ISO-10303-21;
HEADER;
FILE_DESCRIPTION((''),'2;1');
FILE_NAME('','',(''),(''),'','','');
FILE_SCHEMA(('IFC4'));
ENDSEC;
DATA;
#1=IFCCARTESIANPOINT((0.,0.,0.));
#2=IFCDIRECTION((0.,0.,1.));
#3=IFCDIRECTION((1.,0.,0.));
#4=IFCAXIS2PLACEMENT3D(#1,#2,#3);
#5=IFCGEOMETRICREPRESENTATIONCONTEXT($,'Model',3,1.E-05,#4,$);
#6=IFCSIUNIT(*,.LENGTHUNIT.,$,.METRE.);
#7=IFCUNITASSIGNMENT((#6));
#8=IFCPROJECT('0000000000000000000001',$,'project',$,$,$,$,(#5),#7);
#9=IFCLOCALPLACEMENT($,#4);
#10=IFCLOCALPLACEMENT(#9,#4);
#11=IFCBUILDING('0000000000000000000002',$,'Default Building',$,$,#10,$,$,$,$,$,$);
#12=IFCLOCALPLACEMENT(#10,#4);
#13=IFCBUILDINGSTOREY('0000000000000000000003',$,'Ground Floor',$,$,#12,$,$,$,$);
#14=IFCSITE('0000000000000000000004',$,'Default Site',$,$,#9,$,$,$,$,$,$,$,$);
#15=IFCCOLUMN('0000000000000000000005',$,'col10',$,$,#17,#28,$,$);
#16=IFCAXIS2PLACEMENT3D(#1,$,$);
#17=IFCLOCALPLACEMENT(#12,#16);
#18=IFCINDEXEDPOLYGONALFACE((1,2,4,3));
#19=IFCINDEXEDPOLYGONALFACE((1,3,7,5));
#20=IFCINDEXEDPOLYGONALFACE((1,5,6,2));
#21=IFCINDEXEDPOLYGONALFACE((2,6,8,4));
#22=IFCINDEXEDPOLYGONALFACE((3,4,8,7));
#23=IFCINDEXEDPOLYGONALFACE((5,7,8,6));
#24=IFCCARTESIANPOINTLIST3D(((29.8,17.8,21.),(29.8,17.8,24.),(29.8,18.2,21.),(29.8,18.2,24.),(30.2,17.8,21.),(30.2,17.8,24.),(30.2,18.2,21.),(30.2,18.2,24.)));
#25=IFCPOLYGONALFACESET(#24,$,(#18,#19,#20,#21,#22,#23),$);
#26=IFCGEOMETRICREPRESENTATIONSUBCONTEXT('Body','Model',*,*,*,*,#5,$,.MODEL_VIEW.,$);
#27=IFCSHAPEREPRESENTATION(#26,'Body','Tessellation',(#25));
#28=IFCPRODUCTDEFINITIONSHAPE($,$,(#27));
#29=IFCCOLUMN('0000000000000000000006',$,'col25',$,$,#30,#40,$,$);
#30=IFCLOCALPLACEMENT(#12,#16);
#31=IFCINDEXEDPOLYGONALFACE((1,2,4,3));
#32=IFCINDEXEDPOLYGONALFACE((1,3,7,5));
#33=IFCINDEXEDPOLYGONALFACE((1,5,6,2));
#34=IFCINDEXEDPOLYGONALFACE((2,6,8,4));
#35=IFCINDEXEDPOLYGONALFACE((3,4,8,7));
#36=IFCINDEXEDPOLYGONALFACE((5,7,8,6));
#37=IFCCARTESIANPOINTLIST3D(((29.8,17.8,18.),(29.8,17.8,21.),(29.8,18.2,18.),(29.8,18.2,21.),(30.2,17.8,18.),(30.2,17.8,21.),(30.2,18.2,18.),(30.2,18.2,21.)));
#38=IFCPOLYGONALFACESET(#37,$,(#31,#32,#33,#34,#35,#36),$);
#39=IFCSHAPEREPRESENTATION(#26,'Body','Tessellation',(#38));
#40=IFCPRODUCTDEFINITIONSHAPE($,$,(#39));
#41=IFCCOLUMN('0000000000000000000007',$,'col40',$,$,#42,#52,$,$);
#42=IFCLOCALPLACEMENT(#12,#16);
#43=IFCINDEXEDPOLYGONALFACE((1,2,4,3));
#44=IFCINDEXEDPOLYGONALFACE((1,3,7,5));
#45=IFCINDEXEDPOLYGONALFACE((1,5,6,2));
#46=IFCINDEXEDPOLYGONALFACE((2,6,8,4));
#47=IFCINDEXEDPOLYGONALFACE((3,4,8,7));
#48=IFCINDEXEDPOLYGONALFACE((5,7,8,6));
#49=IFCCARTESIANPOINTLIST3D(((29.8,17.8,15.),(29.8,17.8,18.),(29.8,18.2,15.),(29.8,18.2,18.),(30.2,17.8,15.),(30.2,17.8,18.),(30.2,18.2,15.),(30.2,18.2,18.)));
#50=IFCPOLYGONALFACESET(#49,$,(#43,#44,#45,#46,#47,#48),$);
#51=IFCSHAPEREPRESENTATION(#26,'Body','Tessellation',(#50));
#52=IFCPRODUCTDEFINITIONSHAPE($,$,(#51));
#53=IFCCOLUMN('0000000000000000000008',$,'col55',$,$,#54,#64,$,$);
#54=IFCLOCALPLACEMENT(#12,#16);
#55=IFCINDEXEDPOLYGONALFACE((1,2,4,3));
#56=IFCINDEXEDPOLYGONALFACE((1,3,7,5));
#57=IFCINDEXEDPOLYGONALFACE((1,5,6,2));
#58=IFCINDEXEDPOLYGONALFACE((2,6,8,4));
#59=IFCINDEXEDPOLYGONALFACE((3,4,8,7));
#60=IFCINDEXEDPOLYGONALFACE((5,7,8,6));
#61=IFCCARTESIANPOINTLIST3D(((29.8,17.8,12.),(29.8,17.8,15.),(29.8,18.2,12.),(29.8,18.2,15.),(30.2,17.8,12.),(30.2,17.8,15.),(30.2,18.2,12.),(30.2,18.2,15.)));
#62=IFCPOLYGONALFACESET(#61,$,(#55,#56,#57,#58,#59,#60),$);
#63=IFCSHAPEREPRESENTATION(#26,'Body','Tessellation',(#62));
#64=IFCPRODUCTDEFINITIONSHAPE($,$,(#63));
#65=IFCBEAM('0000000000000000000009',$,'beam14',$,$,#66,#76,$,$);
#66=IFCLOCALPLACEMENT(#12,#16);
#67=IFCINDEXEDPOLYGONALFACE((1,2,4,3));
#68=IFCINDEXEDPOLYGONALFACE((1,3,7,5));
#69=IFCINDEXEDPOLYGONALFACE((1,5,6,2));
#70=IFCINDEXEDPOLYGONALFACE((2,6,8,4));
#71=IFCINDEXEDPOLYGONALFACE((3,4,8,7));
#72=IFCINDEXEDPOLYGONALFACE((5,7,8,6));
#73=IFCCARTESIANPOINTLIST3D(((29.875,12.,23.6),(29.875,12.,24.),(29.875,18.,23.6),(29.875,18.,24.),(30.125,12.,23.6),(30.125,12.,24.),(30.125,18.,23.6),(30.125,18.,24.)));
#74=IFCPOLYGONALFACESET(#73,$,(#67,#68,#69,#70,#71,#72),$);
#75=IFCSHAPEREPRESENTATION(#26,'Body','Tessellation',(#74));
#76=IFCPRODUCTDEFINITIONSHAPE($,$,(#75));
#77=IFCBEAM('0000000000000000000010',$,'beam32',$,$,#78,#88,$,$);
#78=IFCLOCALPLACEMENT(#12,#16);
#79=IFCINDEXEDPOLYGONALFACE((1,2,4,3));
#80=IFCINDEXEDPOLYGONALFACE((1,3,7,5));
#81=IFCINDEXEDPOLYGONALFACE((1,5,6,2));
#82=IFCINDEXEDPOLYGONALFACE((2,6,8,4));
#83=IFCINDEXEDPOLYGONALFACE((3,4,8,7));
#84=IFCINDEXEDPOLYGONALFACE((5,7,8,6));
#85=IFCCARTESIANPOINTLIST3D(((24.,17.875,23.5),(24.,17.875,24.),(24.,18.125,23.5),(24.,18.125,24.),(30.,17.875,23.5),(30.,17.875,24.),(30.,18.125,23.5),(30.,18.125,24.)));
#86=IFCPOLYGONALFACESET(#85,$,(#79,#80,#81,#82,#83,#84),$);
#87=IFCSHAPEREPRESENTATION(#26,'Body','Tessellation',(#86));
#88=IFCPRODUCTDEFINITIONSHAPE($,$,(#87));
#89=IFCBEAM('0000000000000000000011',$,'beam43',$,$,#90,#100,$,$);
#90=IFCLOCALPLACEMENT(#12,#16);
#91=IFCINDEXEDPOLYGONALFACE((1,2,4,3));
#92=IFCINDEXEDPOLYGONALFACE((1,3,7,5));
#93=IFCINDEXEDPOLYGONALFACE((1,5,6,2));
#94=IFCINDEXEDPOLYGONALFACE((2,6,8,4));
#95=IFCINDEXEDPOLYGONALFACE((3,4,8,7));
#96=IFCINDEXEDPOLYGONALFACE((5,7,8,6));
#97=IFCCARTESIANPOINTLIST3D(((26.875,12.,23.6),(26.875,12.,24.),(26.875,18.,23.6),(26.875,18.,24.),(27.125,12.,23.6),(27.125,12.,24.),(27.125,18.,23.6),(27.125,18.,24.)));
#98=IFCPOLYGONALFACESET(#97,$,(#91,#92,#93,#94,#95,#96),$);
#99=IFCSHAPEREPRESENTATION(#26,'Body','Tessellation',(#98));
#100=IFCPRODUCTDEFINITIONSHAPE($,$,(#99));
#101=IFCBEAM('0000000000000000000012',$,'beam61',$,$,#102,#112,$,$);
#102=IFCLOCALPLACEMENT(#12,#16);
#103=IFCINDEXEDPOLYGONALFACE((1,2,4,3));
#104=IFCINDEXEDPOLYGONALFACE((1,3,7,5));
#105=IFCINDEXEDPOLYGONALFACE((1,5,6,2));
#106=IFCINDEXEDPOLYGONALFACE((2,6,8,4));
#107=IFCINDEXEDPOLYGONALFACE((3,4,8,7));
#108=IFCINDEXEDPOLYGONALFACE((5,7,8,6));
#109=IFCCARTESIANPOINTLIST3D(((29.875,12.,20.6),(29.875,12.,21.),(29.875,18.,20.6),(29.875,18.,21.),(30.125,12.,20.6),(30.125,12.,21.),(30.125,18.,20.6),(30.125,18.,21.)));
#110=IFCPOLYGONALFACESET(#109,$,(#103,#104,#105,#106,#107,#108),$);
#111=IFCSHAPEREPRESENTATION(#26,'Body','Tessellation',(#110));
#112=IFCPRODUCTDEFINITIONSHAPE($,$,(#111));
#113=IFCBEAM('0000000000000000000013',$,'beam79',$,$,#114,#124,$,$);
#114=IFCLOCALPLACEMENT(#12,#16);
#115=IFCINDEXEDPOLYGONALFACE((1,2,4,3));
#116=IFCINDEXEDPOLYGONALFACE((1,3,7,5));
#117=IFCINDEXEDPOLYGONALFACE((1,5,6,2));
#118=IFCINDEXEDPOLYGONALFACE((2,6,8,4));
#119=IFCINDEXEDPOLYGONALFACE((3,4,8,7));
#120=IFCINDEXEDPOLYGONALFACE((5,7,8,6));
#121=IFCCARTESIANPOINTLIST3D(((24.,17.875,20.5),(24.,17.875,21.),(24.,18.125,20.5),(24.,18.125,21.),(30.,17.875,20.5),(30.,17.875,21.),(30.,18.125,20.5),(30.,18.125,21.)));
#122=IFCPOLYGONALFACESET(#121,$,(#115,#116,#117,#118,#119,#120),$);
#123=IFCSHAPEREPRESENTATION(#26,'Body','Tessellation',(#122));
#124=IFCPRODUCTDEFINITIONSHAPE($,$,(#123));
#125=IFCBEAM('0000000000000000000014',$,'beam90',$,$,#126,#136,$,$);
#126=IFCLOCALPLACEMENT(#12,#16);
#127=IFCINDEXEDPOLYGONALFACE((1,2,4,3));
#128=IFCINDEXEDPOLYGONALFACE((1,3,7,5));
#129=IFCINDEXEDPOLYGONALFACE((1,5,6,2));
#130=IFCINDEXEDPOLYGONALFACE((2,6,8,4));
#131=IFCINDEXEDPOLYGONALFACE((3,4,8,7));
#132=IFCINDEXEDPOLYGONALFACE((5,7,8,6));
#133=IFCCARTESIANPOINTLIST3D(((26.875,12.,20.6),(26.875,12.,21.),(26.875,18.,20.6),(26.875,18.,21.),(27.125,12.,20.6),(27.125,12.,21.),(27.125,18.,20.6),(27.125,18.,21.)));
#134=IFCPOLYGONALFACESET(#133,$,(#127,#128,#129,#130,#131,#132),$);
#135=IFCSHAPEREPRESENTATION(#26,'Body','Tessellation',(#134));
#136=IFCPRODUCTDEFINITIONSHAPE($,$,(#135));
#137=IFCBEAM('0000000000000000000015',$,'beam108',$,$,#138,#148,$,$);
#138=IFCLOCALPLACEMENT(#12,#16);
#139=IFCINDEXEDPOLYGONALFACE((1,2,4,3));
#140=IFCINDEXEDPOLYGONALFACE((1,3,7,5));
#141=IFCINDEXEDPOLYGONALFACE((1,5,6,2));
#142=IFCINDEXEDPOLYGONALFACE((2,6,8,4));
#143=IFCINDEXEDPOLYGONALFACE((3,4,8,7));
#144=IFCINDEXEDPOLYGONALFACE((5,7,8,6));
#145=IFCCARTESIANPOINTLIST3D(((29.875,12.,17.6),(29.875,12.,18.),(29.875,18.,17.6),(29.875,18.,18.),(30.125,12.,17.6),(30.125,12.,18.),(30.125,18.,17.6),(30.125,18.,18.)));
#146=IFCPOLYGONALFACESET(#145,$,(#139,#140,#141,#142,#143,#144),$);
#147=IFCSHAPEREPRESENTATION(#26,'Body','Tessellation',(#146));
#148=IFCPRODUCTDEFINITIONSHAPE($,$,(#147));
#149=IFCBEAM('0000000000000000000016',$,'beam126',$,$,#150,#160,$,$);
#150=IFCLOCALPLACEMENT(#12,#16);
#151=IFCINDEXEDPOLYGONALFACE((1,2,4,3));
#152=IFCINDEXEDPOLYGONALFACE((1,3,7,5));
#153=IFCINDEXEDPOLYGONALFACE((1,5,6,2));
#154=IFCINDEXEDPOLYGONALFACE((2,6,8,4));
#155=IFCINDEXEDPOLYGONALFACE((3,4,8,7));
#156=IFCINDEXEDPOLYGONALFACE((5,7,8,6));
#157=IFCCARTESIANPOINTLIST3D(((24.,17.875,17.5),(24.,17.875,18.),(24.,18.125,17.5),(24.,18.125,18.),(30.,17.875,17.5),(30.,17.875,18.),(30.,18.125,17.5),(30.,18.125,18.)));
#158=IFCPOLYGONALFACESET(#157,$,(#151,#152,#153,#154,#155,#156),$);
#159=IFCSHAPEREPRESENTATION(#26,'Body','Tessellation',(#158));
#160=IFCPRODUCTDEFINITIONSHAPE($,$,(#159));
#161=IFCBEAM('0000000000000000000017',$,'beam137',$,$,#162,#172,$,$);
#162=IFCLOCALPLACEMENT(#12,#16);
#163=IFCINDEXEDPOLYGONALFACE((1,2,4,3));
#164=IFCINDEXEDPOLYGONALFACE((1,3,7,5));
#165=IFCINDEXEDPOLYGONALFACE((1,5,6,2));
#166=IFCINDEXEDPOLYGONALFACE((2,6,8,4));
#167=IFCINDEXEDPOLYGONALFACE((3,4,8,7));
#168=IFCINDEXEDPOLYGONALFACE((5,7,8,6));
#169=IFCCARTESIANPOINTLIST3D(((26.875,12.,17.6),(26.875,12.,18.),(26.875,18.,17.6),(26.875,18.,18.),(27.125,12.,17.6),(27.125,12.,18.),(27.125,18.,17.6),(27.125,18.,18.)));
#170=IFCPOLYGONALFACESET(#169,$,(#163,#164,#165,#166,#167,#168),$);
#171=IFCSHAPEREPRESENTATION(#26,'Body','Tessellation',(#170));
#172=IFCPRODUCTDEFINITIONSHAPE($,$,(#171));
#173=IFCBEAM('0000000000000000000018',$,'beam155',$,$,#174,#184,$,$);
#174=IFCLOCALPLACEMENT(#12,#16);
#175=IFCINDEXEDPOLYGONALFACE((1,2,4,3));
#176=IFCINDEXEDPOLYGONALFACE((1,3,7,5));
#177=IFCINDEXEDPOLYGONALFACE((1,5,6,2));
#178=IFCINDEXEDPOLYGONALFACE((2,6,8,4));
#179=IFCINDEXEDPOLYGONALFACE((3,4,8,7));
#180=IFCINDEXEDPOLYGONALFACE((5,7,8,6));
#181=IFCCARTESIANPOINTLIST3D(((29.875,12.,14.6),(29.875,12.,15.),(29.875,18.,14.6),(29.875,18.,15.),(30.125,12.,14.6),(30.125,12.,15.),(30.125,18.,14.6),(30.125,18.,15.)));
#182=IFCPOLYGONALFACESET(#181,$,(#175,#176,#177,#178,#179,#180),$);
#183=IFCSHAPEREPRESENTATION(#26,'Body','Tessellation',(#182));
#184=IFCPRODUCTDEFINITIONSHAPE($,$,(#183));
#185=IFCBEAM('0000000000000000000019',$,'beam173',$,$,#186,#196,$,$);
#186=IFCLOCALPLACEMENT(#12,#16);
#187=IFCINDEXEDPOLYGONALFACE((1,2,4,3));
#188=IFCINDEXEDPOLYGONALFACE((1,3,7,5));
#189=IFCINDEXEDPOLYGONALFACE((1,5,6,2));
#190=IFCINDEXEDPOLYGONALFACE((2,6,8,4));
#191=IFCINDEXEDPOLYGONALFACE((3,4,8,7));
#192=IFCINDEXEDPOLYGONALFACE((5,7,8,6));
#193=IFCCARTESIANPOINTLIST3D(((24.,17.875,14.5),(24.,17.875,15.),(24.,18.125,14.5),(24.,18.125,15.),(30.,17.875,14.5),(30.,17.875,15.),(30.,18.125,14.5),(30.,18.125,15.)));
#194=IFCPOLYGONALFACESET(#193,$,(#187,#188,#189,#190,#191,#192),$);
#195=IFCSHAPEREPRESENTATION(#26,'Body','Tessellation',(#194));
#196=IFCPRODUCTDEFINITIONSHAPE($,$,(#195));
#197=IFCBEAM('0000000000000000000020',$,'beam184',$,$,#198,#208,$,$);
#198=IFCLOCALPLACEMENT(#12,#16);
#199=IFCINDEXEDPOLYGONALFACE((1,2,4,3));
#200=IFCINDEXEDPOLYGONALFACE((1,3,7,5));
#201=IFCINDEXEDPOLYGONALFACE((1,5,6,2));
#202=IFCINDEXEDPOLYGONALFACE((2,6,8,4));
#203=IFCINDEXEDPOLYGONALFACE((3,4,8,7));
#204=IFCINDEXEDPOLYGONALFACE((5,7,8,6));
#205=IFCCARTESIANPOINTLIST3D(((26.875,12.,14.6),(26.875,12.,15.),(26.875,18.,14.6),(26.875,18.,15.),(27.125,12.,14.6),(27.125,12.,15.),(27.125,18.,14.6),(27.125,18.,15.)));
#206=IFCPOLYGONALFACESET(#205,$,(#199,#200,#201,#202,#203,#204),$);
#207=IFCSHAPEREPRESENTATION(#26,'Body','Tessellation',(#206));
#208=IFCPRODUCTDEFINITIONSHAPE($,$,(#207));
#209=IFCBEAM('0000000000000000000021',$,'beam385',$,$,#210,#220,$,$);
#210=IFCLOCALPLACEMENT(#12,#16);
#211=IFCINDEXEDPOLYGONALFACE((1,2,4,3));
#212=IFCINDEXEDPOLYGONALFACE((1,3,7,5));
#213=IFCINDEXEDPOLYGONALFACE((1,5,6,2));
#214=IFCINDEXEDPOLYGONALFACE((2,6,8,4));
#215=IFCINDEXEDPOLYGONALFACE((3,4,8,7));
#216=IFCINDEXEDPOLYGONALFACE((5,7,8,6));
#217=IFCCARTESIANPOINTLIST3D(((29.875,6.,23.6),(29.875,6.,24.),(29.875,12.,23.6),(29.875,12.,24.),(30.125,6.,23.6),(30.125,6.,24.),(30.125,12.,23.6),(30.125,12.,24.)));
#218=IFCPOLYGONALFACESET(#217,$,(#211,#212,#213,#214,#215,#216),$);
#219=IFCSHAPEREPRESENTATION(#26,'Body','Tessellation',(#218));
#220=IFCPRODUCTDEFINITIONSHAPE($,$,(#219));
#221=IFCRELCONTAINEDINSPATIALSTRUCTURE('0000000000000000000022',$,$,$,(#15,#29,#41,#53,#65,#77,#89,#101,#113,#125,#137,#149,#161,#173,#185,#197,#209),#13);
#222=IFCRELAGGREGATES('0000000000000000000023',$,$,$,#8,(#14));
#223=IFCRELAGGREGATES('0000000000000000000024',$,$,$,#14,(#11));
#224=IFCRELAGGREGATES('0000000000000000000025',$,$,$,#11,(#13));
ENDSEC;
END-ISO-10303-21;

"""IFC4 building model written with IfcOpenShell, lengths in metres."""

from ifc_helpers import new_model, si_unit, frame, origin_with_axes, place, context, subcontext, project, spatial, indexed_curve, outline, extrude, element, save


model = new_model("IFC4")

# Units and contexts
model_context = context("Model", 3, precision=1e-05, world=origin_with_axes())
body_context = subcontext(model_context, "Body", "Model", "MODEL_VIEW")
ifc_project = project(units=[si_unit("LENGTHUNIT", "METRE")], contexts=[model_context])

# Site, building, storey
site_placement = place(None, origin_with_axes())
site = spatial("IfcSite", under=ifc_project, at=site_placement, Name="Default Site")
building_placement = place(site_placement, origin_with_axes())
building = spatial("IfcBuilding", under=site, at=building_placement, Name="Default Building")
storey_placement = place(building_placement, origin_with_axes())
storey = spatial("IfcBuildingStorey", under=building, at=storey_placement, Name="Ground Floor")

# Columns
for number, where, z_axis, x_axis, name in (
    (1, (29.8, 17.8, 21.0), (0.0, 0.0, 1.0), (1.0, 0.0, 0.0), "col10"),
    (2, (29.8, 17.8, 18.0), (0.0, 0.0, 1.0), (1.0, 0.0, 0.0), "col25"),
    (3, (29.8, 17.8, 15.0), (0.0, 0.0, 1.0), (1.0, 0.0, 0.0), "col40"),
    (4, (29.8, 17.8, 12.0), (0.0, 0.0, 1.0), (1.0, 0.0, 0.0), "col55"),
):
    element("IfcColumn", number, at=place(storey_placement, frame(where, z_axis=z_axis, x_axis=x_axis)), inside=storey, Name=name, context=body_context, shape_type="SweptSolid", body=[
        extrude(outline(indexed_curve([(0.0, 0.0), (0.0, 0.4), (0.4, 0.4), (0.4, 0.0), (0.0, 0.0)], self_intersect=False)), origin_with_axes(), (0.0, 0.0, 1.0), 3.0),
    ])

# Beams
beam_1_placement = place(storey_placement, frame((30.125, 12.0, 23.6), z_axis=(0.0, 0.0, 1.0), x_axis=(0.0, 1.0, 0.0)))
element("IfcBeam", 5, at=beam_1_placement, inside=storey, Name="beam14", context=body_context, shape_type="SweptSolid", body=[
    extrude(outline(indexed_curve([(0.0, 0.0), (0.0, 0.25), (6.0, 0.25), (6.0, 0.0), (0.0, 0.0)], self_intersect=False)), origin_with_axes(), (0.0, 0.0, 1.0), 0.4),
])
beam_2_placement = place(storey_placement, frame((24.0, 17.875, 23.5), z_axis=(0.0, 0.0, 1.0), x_axis=(1.0, 0.0, 0.0)))
element("IfcBeam", 6, at=beam_2_placement, inside=storey, Name="beam32", context=body_context, shape_type="SweptSolid", body=[
    extrude(outline(indexed_curve([(0.0, 0.0), (0.0, 0.25), (6.0, 0.25), (6.0, 0.0), (0.0, 0.0)], self_intersect=False)), origin_with_axes(), (0.0, 0.0, 1.0), 0.5),
])
for number, where, z_axis, x_axis, name in (
    (7, (26.875, 18.0, 23.6), (0.0, 0.0, 1.0), (0.0, -1.0, 0.0), "beam43"),
    (8, (30.125, 12.0, 20.6), (0.0, 0.0, 1.0), (0.0, 1.0, 0.0), "beam61"),
):
    element("IfcBeam", number, at=place(storey_placement, frame(where, z_axis=z_axis, x_axis=x_axis)), inside=storey, Name=name, context=body_context, shape_type="SweptSolid", body=[
        extrude(outline(indexed_curve([(0.0, 0.0), (0.0, 0.25), (6.0, 0.25), (6.0, 0.0), (0.0, 0.0)], self_intersect=False)), origin_with_axes(), (0.0, 0.0, 1.0), 0.4),
    ])
beam_3_placement = place(storey_placement, frame((24.0, 17.875, 20.5), z_axis=(0.0, 0.0, 1.0), x_axis=(1.0, 0.0, 0.0)))
element("IfcBeam", 9, at=beam_3_placement, inside=storey, Name="beam79", context=body_context, shape_type="SweptSolid", body=[
    extrude(outline(indexed_curve([(0.0, 0.0), (0.0, 0.25), (6.0, 0.25), (6.0, 0.0), (0.0, 0.0)], self_intersect=False)), origin_with_axes(), (0.0, 0.0, 1.0), 0.5),
])
for number, where, z_axis, x_axis, name in (
    (10, (26.875, 18.0, 20.6), (0.0, 0.0, 1.0), (0.0, -1.0, 0.0), "beam90"),
    (11, (30.125, 12.0, 17.6), (0.0, 0.0, 1.0), (0.0, 1.0, 0.0), "beam108"),
):
    element("IfcBeam", number, at=place(storey_placement, frame(where, z_axis=z_axis, x_axis=x_axis)), inside=storey, Name=name, context=body_context, shape_type="SweptSolid", body=[
        extrude(outline(indexed_curve([(0.0, 0.0), (0.0, 0.25), (6.0, 0.25), (6.0, 0.0), (0.0, 0.0)], self_intersect=False)), origin_with_axes(), (0.0, 0.0, 1.0), 0.4),
    ])
beam_4_placement = place(storey_placement, frame((24.0, 17.875, 17.5), z_axis=(0.0, 0.0, 1.0), x_axis=(1.0, 0.0, 0.0)))
element("IfcBeam", 12, at=beam_4_placement, inside=storey, Name="beam126", context=body_context, shape_type="SweptSolid", body=[
    extrude(outline(indexed_curve([(0.0, 0.0), (0.0, 0.25), (6.0, 0.25), (6.0, 0.0), (0.0, 0.0)], self_intersect=False)), origin_with_axes(), (0.0, 0.0, 1.0), 0.5),
])
for number, where, z_axis, x_axis, name in (
    (13, (26.875, 18.0, 17.6), (0.0, 0.0, 1.0), (0.0, -1.0, 0.0), "beam137"),
    (14, (30.125, 12.0, 14.6), (0.0, 0.0, 1.0), (0.0, 1.0, 0.0), "beam155"),
):
    element("IfcBeam", number, at=place(storey_placement, frame(where, z_axis=z_axis, x_axis=x_axis)), inside=storey, Name=name, context=body_context, shape_type="SweptSolid", body=[
        extrude(outline(indexed_curve([(0.0, 0.0), (0.0, 0.25), (6.0, 0.25), (6.0, 0.0), (0.0, 0.0)], self_intersect=False)), origin_with_axes(), (0.0, 0.0, 1.0), 0.4),
    ])
beam_5_placement = place(storey_placement, frame((24.0, 17.875, 14.5), z_axis=(0.0, 0.0, 1.0), x_axis=(1.0, 0.0, 0.0)))
element("IfcBeam", 15, at=beam_5_placement, inside=storey, Name="beam173", context=body_context, shape_type="SweptSolid", body=[
    extrude(outline(indexed_curve([(0.0, 0.0), (0.0, 0.25), (6.0, 0.25), (6.0, 0.0), (0.0, 0.0)], self_intersect=False)), origin_with_axes(), (0.0, 0.0, 1.0), 0.5),
])
for number, where, z_axis, x_axis, name in (
    (16, (26.875, 18.0, 14.6), (0.0, 0.0, 1.0), (0.0, -1.0, 0.0), "beam184"),
    (17, (29.875, 12.0, 23.6), (0.0, 0.0, 1.0), (0.0, -1.0, 0.0), "beam385"),
):
    element("IfcBeam", number, at=place(storey_placement, frame(where, z_axis=z_axis, x_axis=x_axis)), inside=storey, Name=name, context=body_context, shape_type="SweptSolid", body=[
        extrude(outline(indexed_curve([(0.0, 0.0), (0.0, 0.25), (6.0, 0.25), (6.0, 0.0), (0.0, 0.0)], self_intersect=False)), origin_with_axes(), (0.0, 0.0, 1.0), 0.4),
    ])

save(model, "model.ifc")
